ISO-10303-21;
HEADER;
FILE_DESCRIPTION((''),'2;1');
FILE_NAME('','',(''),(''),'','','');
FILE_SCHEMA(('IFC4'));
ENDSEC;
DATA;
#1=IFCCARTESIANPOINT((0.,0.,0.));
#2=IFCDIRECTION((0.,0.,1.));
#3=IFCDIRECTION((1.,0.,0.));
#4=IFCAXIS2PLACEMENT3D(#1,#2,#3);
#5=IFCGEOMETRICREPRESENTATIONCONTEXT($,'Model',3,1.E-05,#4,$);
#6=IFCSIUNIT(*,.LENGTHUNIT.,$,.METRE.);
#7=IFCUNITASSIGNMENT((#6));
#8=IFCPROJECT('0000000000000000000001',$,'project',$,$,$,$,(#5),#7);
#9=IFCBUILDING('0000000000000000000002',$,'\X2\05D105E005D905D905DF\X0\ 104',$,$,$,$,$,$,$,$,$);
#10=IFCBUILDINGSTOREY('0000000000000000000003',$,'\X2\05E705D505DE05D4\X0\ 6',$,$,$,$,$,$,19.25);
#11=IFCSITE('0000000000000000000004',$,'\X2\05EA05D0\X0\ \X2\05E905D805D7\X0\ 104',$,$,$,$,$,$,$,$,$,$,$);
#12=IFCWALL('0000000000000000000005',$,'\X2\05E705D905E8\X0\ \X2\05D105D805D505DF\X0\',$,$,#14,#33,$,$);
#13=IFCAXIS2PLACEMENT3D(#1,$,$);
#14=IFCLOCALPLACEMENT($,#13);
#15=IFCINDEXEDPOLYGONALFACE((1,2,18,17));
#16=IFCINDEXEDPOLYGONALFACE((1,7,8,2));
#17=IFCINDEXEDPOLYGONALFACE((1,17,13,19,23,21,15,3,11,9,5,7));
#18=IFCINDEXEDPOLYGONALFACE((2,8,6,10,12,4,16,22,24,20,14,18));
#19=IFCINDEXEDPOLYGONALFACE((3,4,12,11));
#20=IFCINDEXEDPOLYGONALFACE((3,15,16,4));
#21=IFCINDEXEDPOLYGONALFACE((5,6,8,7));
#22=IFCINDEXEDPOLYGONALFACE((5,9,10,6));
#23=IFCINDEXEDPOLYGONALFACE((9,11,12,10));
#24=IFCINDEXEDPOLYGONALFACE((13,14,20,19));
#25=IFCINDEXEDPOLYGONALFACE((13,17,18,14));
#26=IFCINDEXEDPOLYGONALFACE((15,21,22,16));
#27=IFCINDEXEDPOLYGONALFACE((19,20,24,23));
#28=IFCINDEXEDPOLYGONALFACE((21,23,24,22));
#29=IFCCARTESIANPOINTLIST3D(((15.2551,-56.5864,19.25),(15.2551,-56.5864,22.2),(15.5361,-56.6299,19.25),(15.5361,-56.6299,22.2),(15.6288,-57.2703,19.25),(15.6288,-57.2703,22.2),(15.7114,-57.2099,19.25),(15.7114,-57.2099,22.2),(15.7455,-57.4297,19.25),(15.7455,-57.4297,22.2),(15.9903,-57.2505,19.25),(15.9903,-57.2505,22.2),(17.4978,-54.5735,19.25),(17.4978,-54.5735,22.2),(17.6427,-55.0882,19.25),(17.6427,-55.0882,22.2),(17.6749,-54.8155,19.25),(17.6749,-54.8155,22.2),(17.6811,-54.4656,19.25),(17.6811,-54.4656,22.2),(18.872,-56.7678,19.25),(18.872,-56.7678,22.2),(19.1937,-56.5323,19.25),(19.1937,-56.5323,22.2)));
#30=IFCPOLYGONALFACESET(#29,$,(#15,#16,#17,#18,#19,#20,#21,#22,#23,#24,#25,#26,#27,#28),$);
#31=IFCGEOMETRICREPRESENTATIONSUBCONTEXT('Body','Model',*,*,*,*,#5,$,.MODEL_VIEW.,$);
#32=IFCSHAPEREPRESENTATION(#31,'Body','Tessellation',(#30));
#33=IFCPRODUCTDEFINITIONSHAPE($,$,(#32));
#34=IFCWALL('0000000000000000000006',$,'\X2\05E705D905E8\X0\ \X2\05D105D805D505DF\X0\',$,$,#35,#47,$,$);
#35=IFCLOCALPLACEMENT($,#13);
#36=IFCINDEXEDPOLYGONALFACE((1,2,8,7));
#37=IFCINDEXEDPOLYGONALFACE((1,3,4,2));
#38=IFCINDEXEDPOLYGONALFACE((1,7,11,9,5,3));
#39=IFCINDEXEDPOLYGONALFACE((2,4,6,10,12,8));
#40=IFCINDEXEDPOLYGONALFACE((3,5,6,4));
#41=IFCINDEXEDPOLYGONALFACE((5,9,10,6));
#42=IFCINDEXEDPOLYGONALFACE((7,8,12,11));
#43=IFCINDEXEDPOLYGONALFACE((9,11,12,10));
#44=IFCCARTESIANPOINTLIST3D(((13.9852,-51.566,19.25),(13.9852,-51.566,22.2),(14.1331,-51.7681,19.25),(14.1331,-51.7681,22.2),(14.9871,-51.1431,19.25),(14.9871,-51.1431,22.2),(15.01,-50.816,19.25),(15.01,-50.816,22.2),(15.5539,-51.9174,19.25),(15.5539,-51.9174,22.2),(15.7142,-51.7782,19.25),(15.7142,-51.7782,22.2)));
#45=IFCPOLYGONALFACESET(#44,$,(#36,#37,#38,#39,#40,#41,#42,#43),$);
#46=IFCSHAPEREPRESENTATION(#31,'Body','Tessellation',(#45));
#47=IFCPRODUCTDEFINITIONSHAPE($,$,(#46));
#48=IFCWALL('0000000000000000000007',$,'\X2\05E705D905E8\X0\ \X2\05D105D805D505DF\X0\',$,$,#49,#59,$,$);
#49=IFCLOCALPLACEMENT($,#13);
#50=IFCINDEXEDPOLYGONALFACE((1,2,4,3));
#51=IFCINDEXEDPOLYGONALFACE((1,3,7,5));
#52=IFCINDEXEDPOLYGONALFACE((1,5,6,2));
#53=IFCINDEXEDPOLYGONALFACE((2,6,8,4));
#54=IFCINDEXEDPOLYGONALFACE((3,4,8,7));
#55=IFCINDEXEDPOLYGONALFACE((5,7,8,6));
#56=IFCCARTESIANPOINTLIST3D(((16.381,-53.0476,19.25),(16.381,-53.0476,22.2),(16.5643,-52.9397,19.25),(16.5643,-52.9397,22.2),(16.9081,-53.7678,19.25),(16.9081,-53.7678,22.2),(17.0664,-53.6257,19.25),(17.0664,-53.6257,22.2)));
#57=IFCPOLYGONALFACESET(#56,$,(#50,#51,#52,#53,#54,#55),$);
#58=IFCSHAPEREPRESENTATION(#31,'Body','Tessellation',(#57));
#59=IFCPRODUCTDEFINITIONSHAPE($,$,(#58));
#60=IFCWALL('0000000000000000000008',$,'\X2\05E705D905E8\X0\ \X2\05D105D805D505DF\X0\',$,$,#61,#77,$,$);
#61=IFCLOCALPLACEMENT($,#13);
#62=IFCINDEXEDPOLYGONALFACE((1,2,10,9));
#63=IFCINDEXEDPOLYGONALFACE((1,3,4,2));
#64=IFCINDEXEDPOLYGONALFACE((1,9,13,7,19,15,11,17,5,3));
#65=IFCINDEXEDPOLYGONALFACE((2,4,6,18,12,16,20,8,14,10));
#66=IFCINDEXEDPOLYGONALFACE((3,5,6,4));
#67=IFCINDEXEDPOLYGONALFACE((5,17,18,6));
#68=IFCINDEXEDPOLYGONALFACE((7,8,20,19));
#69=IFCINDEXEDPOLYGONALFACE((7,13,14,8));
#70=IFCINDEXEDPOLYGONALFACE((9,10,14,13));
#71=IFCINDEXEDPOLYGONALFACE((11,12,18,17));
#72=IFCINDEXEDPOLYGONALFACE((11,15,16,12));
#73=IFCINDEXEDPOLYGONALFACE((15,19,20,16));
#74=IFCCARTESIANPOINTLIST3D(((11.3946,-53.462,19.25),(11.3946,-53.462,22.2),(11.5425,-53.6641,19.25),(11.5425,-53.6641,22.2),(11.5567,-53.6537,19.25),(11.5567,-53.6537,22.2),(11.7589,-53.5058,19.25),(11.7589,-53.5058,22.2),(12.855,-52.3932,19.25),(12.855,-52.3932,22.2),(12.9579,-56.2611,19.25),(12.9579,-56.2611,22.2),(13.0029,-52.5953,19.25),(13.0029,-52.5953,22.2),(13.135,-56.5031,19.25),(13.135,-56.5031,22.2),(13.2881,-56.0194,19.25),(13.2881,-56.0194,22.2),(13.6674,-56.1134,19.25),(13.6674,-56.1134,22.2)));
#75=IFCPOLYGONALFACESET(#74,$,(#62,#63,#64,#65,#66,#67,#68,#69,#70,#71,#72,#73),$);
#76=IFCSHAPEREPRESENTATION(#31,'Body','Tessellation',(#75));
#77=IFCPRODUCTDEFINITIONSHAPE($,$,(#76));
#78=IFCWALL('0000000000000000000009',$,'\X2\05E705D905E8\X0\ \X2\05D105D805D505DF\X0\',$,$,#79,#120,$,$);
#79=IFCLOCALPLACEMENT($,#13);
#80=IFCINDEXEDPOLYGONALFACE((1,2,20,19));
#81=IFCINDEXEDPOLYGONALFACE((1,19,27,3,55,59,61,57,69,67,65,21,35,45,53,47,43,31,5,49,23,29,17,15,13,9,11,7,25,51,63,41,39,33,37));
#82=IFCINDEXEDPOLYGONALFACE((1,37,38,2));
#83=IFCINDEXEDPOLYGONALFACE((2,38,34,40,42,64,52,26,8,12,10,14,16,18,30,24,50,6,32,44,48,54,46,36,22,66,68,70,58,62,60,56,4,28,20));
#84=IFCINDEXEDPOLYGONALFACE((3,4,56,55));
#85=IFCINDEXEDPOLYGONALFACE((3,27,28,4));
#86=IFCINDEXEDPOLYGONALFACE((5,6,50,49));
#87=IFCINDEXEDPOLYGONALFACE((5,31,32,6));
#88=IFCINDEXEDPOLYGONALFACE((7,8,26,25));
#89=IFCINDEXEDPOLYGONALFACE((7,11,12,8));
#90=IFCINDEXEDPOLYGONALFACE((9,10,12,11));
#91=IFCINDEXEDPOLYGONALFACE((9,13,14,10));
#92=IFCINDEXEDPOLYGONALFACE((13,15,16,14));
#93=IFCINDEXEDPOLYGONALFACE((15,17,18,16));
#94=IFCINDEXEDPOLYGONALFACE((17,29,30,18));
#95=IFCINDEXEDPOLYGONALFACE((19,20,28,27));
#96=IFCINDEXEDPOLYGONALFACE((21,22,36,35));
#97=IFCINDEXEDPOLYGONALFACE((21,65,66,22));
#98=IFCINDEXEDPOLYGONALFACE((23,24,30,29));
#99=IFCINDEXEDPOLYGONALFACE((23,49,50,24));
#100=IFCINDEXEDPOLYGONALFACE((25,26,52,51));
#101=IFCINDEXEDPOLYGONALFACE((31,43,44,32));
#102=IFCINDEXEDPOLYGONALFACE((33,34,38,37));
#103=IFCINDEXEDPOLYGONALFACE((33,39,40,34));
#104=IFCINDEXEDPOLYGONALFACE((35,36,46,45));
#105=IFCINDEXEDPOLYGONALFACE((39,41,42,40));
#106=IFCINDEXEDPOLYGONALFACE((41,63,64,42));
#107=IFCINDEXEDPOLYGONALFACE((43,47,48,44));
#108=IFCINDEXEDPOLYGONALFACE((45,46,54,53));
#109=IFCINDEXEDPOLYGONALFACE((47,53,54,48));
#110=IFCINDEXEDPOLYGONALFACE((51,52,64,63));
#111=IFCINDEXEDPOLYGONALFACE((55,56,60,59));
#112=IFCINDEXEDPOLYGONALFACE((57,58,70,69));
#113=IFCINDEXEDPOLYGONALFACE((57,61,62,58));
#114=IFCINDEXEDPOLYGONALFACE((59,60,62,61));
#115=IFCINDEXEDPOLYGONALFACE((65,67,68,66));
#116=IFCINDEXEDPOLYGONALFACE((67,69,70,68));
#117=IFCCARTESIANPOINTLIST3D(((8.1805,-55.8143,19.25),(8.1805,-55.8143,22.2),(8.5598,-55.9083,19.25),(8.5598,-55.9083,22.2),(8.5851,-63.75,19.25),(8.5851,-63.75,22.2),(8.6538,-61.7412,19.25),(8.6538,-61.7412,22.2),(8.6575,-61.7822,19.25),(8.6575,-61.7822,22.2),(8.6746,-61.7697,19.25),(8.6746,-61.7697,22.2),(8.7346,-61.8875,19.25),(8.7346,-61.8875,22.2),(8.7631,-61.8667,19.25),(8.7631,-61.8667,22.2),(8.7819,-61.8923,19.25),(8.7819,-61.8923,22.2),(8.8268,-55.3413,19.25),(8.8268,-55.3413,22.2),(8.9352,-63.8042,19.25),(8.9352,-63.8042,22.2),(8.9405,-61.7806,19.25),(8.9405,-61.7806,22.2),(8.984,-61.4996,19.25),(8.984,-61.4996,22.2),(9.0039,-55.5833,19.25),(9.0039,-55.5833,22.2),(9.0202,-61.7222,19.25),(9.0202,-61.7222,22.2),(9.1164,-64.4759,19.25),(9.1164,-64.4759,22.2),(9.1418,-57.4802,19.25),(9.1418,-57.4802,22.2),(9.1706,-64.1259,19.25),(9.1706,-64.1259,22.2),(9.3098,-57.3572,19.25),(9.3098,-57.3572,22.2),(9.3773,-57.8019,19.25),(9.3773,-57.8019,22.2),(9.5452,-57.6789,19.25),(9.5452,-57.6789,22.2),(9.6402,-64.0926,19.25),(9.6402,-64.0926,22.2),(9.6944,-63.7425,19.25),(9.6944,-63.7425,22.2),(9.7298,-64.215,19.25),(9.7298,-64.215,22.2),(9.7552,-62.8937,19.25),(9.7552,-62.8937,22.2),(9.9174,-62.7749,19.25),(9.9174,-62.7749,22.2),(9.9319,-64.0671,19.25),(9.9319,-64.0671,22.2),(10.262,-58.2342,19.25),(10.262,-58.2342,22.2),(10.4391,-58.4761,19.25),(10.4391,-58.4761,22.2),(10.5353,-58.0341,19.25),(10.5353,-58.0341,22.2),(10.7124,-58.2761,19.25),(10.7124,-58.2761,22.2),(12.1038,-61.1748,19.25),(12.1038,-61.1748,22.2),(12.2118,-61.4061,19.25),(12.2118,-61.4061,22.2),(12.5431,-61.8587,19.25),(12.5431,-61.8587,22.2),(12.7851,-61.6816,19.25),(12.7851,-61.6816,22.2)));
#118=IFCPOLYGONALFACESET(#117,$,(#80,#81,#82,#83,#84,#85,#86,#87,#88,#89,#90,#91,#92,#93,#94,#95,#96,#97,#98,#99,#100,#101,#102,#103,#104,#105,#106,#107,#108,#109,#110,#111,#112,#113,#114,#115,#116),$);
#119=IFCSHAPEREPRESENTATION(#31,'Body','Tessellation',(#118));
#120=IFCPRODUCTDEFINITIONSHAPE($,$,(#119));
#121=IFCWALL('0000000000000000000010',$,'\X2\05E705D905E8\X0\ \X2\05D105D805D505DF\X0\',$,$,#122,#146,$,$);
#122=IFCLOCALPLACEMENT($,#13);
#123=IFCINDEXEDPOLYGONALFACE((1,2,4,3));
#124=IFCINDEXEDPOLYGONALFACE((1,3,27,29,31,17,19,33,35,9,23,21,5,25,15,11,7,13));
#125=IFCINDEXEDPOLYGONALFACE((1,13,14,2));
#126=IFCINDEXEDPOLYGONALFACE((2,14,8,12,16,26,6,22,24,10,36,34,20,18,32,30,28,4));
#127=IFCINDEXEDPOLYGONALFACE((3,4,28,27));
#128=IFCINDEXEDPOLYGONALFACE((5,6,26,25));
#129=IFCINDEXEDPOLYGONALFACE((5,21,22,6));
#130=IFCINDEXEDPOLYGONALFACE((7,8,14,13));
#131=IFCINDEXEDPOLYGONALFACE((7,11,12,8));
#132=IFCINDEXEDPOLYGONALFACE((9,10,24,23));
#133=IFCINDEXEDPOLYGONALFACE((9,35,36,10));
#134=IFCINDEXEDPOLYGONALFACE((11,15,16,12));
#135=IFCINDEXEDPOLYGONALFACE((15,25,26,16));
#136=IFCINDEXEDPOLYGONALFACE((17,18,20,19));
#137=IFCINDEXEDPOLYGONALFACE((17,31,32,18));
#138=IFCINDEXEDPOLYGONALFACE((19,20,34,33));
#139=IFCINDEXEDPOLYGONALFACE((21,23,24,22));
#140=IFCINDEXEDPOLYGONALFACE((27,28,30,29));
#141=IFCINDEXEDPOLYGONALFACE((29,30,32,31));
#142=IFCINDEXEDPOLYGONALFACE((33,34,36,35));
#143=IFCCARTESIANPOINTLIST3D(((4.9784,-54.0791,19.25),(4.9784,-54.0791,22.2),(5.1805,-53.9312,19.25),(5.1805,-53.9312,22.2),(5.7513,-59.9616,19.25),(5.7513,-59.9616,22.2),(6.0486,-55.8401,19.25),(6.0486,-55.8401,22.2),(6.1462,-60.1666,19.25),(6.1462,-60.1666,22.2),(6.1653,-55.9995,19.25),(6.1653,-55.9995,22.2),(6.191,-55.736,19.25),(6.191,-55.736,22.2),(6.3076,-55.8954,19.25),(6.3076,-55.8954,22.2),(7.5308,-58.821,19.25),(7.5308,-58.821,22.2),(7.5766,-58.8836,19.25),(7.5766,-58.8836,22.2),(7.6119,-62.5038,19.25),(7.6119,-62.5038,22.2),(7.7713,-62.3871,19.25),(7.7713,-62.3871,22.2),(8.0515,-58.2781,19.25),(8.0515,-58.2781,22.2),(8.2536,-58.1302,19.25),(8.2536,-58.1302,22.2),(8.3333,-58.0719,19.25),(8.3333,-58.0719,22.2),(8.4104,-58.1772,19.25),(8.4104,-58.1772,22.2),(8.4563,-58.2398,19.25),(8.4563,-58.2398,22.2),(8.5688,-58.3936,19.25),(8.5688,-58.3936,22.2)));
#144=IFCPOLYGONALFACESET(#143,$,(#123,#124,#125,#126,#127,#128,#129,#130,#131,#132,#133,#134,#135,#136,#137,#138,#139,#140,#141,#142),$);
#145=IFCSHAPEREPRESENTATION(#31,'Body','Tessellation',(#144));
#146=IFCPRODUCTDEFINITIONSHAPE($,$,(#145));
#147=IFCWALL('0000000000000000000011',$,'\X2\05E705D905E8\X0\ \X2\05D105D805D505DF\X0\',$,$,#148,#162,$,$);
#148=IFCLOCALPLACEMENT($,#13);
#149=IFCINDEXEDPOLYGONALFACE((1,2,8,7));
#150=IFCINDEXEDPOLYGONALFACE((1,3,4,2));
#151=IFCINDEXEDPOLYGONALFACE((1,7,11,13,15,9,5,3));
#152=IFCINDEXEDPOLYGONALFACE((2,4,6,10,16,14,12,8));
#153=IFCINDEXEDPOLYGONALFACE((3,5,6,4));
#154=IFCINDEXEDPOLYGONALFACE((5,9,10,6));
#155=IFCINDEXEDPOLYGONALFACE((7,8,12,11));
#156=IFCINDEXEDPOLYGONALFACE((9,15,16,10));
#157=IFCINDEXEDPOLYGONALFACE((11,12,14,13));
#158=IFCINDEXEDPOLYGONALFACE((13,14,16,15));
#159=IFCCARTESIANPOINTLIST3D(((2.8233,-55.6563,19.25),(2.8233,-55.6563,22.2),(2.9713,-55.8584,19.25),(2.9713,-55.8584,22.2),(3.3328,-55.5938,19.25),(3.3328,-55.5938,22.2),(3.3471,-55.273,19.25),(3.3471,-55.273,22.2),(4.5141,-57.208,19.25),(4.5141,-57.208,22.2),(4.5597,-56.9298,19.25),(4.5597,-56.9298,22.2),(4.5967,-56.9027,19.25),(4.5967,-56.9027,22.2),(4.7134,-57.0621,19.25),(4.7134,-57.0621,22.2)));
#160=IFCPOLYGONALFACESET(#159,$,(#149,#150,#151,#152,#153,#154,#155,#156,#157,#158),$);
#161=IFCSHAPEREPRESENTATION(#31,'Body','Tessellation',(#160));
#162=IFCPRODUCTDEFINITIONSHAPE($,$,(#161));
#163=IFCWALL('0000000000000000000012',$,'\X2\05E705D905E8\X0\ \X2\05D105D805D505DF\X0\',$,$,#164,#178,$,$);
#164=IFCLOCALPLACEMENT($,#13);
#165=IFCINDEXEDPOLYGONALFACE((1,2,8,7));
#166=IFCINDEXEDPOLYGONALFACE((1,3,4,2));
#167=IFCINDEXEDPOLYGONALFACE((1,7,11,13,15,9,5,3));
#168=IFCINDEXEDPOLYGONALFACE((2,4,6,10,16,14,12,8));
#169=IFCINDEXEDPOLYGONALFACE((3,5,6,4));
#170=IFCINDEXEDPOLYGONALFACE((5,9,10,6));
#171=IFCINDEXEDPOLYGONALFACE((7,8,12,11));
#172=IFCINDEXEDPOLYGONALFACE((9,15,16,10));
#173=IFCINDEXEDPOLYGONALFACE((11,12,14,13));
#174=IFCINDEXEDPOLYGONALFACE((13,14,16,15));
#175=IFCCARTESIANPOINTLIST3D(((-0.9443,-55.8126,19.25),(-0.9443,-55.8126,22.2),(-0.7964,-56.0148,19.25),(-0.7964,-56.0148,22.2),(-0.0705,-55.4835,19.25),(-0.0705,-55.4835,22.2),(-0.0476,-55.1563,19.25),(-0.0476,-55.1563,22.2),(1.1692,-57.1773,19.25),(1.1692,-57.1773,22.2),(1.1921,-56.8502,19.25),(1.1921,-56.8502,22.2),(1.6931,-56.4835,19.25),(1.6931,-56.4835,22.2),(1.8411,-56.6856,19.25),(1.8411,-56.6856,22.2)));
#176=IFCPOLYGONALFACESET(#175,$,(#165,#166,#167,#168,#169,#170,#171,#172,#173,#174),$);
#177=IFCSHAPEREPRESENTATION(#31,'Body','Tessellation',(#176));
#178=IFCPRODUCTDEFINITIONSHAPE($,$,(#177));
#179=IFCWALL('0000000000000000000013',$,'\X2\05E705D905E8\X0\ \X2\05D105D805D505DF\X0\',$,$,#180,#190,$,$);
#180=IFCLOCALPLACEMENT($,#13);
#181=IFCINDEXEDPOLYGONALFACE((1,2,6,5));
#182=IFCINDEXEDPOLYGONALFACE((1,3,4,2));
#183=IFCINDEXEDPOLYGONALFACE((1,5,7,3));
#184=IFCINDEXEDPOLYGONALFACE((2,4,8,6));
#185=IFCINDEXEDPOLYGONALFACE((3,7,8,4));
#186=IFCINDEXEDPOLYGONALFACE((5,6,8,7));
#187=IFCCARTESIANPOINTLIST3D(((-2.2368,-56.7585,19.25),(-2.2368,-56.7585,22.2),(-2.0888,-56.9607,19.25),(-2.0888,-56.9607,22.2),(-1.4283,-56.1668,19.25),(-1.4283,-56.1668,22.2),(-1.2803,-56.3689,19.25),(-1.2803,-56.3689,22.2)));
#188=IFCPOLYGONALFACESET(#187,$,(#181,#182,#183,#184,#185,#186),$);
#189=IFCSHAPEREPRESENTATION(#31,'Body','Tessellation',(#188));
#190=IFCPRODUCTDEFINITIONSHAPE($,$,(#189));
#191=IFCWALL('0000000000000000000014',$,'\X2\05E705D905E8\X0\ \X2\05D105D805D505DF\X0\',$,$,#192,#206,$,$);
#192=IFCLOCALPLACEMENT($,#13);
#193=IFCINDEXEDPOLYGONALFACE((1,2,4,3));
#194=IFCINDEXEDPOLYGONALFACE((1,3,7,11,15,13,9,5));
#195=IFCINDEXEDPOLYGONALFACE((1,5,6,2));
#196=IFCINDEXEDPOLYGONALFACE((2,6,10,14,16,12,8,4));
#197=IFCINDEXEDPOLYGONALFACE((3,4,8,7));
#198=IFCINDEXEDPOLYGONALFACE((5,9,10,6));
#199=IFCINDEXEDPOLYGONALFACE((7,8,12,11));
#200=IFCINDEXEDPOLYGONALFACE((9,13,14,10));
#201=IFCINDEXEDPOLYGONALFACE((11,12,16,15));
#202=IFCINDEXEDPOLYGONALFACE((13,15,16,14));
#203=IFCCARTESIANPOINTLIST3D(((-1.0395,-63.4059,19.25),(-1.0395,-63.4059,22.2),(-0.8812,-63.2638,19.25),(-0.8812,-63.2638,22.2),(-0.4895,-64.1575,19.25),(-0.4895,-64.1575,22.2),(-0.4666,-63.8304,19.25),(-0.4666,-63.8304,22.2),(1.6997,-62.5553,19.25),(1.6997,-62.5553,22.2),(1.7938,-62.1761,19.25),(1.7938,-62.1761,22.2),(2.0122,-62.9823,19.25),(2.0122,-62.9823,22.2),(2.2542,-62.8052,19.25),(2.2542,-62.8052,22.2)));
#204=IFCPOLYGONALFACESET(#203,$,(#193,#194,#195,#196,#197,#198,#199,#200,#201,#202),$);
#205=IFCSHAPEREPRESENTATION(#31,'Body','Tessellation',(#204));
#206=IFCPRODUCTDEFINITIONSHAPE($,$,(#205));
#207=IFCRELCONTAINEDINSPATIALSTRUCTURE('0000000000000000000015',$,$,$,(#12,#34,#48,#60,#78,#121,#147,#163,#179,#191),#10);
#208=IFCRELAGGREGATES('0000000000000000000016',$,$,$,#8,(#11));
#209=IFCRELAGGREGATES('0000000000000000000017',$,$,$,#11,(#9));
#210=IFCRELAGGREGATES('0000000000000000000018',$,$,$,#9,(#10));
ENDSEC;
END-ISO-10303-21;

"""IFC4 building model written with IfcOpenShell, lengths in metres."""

from ifc_helpers import new_model, si_unit, frame, origin_with_axes, context, subcontext, project, spatial, polyline, outline, extrude, element, save


model = new_model("IFC4")

# Units and contexts
model_context = context("Model", 3, precision=1e-05, world=origin_with_axes())
body_context = subcontext(model_context, "Body", "Model", "MODEL_VIEW")
ifc_project = project(units=[si_unit("LENGTHUNIT", "METRE")], contexts=[model_context])

# Site, building, storey
site = spatial("IfcSite", under=ifc_project, Name="תא שטח 104")
building = spatial("IfcBuilding", under=site, Name="בניין 104")
storey = spatial("IfcBuildingStorey", under=building, Name="קומה 6", Elevation=19.25)

# Walls
element("IfcWall", 1, inside=storey, Name="קיר בטון", context=body_context, shape_type="SweptSolid", body=[
    extrude(outline(polyline([(17.6749, -54.8155), (15.2551, -56.5864), (15.7114, -57.2099), (15.6288, -57.2703), (15.7455, -57.4297), (15.9903, -57.2505), (15.5361, -56.6299), (17.6427, -55.0882), (18.872, -56.7678), (19.1937, -56.5323), (17.6811, -54.4656), (17.4978, -54.5735), (17.6749, -54.8155)])), frame((0.0, 0.0, 19.25)), (0.0, 0.0, 1.0), 2.95),
])
element("IfcWall", 2, inside=storey, Name="קיר בטון", context=body_context, shape_type="SweptSolid", body=[
    extrude(outline(polyline([(13.9852, -51.566), (14.1331, -51.7681), (14.9871, -51.1431), (15.5539, -51.9174), (15.7142, -51.7782), (15.01, -50.816), (13.9852, -51.566)])), frame((0.0, 0.0, 19.25)), (0.0, 0.0, 1.0), 2.95),
])
element("IfcWall", 3, inside=storey, Name="קיר בטון", context=body_context, shape_type="SweptSolid", body=[
    extrude(outline(polyline([(16.381, -53.0476), (16.9081, -53.7678), (17.0664, -53.6257), (16.5643, -52.9397), (16.381, -53.0476)])), frame((0.0, 0.0, 19.25)), (0.0, 0.0, 1.0), 2.95),
])
element("IfcWall", 4, inside=storey, Name="קיר בטון", context=body_context, shape_type="SweptSolid", body=[
    extrude(outline(polyline([(13.6674, -56.1134), (11.7589, -53.5058), (13.0029, -52.5953), (12.855, -52.3932), (11.3946, -53.462), (11.5425, -53.6641), (11.5567, -53.6537), (13.2881, -56.0194), (12.9579, -56.2611), (13.135, -56.5031), (13.6674, -56.1134)])), frame((0.0, 0.0, 19.25)), (0.0, 0.0, 1.0), 2.95),
])
element("IfcWall", 5, inside=storey, Name="קיר בטון", context=body_context, shape_type="SweptSolid", body=[
    extrude(outline(polyline([(8.1805, -55.8143), (9.3098, -57.3572), (9.1418, -57.4802), (9.3773, -57.8019), (9.5452, -57.6789), (12.1038, -61.1748), (9.9174, -62.7749), (8.984, -61.4996), (8.6538, -61.7412), (8.6746, -61.7697), (8.6575, -61.7822), (8.7346, -61.8875), (8.7631, -61.8667), (8.7819, -61.8923), (9.0202, -61.7222), (8.9405, -61.7806), (9.7552, -62.8937), (8.5851, -63.75), (9.1164, -64.4759), (9.6402, -64.0926), (9.7298, -64.215), (9.9319, -64.0671), (9.6944, -63.7425), (9.1706, -64.1259), (8.9352, -63.8042), (12.2118, -61.4061), (12.5431, -61.8587), (12.7851, -61.6816), (10.4391, -58.4761), (10.7124, -58.2761), (10.5353, -58.0341), (10.262, -58.2342), (8.5598, -55.9083), (9.0039, -55.5833), (8.8268, -55.3413), (8.1805, -55.8143)])), frame((0.0, 0.0, 19.25)), (0.0, 0.0, 1.0), 2.95),
])
element("IfcWall", 6, inside=storey, Name="קיר בטון", context=body_context, shape_type="SweptSolid", body=[
    extrude(outline(polyline([(7.5308, -58.821), (8.4104, -58.1772), (8.3333, -58.0719), (8.2536, -58.1302), (5.1805, -53.9312), (4.9784, -54.0791), (6.191, -55.736), (6.0486, -55.8401), (6.1653, -55.9995), (6.3076, -55.8954), (8.0515, -58.2781), (5.7513, -59.9616), (7.6119, -62.5038), (7.7713, -62.3871), (6.1462, -60.1666), (8.5688, -58.3936), (8.4563, -58.2398), (7.5766, -58.8836), (7.5308, -58.821)])), frame((0.0, 0.0, 19.25)), (0.0, 0.0, 1.0), 2.95),
])
element("IfcWall", 7, inside=storey, Name="קיר בטון", context=body_context, shape_type="SweptSolid", body=[
    extrude(outline(polyline([(2.8233, -55.6563), (2.9713, -55.8584), (3.3328, -55.5938), (4.5141, -57.208), (4.7134, -57.0621), (4.5967, -56.9027), (4.5597, -56.9298), (3.3471, -55.273), (2.8233, -55.6563)])), frame((0.0, 0.0, 19.25)), (0.0, 0.0, 1.0), 2.95),
])
element("IfcWall", 8, inside=storey, Name="קיר בטון", context=body_context, shape_type="SweptSolid", body=[
    extrude(outline(polyline([(1.1921, -56.8502), (-0.0476, -55.1563), (-0.9443, -55.8126), (-0.7964, -56.0148), (-0.0705, -55.4835), (1.1692, -57.1773), (1.8411, -56.6856), (1.6931, -56.4835), (1.1921, -56.8502)])), frame((0.0, 0.0, 19.25)), (0.0, 0.0, 1.0), 2.95),
])
element("IfcWall", 9, inside=storey, Name="קיר בטון", context=body_context, shape_type="SweptSolid", body=[
    extrude(outline(polyline([(-2.0888, -56.9607), (-1.2803, -56.3689), (-1.4283, -56.1668), (-2.2368, -56.7585), (-2.0888, -56.9607)])), frame((0.0, 0.0, 19.25)), (0.0, 0.0, 1.0), 2.95),
])
element("IfcWall", 10, inside=storey, Name="קיר בטון", context=body_context, shape_type="SweptSolid", body=[
    extrude(outline(polyline([(-0.8812, -63.2638), (-1.0395, -63.4059), (-0.4895, -64.1575), (1.6997, -62.5553), (2.0122, -62.9823), (2.2542, -62.8052), (1.7938, -62.1761), (-0.4666, -63.8304), (-0.8812, -63.2638)])), frame((0.0, 0.0, 19.25)), (0.0, 0.0, 1.0), 2.95),
])

save(model, "model.ifc")
